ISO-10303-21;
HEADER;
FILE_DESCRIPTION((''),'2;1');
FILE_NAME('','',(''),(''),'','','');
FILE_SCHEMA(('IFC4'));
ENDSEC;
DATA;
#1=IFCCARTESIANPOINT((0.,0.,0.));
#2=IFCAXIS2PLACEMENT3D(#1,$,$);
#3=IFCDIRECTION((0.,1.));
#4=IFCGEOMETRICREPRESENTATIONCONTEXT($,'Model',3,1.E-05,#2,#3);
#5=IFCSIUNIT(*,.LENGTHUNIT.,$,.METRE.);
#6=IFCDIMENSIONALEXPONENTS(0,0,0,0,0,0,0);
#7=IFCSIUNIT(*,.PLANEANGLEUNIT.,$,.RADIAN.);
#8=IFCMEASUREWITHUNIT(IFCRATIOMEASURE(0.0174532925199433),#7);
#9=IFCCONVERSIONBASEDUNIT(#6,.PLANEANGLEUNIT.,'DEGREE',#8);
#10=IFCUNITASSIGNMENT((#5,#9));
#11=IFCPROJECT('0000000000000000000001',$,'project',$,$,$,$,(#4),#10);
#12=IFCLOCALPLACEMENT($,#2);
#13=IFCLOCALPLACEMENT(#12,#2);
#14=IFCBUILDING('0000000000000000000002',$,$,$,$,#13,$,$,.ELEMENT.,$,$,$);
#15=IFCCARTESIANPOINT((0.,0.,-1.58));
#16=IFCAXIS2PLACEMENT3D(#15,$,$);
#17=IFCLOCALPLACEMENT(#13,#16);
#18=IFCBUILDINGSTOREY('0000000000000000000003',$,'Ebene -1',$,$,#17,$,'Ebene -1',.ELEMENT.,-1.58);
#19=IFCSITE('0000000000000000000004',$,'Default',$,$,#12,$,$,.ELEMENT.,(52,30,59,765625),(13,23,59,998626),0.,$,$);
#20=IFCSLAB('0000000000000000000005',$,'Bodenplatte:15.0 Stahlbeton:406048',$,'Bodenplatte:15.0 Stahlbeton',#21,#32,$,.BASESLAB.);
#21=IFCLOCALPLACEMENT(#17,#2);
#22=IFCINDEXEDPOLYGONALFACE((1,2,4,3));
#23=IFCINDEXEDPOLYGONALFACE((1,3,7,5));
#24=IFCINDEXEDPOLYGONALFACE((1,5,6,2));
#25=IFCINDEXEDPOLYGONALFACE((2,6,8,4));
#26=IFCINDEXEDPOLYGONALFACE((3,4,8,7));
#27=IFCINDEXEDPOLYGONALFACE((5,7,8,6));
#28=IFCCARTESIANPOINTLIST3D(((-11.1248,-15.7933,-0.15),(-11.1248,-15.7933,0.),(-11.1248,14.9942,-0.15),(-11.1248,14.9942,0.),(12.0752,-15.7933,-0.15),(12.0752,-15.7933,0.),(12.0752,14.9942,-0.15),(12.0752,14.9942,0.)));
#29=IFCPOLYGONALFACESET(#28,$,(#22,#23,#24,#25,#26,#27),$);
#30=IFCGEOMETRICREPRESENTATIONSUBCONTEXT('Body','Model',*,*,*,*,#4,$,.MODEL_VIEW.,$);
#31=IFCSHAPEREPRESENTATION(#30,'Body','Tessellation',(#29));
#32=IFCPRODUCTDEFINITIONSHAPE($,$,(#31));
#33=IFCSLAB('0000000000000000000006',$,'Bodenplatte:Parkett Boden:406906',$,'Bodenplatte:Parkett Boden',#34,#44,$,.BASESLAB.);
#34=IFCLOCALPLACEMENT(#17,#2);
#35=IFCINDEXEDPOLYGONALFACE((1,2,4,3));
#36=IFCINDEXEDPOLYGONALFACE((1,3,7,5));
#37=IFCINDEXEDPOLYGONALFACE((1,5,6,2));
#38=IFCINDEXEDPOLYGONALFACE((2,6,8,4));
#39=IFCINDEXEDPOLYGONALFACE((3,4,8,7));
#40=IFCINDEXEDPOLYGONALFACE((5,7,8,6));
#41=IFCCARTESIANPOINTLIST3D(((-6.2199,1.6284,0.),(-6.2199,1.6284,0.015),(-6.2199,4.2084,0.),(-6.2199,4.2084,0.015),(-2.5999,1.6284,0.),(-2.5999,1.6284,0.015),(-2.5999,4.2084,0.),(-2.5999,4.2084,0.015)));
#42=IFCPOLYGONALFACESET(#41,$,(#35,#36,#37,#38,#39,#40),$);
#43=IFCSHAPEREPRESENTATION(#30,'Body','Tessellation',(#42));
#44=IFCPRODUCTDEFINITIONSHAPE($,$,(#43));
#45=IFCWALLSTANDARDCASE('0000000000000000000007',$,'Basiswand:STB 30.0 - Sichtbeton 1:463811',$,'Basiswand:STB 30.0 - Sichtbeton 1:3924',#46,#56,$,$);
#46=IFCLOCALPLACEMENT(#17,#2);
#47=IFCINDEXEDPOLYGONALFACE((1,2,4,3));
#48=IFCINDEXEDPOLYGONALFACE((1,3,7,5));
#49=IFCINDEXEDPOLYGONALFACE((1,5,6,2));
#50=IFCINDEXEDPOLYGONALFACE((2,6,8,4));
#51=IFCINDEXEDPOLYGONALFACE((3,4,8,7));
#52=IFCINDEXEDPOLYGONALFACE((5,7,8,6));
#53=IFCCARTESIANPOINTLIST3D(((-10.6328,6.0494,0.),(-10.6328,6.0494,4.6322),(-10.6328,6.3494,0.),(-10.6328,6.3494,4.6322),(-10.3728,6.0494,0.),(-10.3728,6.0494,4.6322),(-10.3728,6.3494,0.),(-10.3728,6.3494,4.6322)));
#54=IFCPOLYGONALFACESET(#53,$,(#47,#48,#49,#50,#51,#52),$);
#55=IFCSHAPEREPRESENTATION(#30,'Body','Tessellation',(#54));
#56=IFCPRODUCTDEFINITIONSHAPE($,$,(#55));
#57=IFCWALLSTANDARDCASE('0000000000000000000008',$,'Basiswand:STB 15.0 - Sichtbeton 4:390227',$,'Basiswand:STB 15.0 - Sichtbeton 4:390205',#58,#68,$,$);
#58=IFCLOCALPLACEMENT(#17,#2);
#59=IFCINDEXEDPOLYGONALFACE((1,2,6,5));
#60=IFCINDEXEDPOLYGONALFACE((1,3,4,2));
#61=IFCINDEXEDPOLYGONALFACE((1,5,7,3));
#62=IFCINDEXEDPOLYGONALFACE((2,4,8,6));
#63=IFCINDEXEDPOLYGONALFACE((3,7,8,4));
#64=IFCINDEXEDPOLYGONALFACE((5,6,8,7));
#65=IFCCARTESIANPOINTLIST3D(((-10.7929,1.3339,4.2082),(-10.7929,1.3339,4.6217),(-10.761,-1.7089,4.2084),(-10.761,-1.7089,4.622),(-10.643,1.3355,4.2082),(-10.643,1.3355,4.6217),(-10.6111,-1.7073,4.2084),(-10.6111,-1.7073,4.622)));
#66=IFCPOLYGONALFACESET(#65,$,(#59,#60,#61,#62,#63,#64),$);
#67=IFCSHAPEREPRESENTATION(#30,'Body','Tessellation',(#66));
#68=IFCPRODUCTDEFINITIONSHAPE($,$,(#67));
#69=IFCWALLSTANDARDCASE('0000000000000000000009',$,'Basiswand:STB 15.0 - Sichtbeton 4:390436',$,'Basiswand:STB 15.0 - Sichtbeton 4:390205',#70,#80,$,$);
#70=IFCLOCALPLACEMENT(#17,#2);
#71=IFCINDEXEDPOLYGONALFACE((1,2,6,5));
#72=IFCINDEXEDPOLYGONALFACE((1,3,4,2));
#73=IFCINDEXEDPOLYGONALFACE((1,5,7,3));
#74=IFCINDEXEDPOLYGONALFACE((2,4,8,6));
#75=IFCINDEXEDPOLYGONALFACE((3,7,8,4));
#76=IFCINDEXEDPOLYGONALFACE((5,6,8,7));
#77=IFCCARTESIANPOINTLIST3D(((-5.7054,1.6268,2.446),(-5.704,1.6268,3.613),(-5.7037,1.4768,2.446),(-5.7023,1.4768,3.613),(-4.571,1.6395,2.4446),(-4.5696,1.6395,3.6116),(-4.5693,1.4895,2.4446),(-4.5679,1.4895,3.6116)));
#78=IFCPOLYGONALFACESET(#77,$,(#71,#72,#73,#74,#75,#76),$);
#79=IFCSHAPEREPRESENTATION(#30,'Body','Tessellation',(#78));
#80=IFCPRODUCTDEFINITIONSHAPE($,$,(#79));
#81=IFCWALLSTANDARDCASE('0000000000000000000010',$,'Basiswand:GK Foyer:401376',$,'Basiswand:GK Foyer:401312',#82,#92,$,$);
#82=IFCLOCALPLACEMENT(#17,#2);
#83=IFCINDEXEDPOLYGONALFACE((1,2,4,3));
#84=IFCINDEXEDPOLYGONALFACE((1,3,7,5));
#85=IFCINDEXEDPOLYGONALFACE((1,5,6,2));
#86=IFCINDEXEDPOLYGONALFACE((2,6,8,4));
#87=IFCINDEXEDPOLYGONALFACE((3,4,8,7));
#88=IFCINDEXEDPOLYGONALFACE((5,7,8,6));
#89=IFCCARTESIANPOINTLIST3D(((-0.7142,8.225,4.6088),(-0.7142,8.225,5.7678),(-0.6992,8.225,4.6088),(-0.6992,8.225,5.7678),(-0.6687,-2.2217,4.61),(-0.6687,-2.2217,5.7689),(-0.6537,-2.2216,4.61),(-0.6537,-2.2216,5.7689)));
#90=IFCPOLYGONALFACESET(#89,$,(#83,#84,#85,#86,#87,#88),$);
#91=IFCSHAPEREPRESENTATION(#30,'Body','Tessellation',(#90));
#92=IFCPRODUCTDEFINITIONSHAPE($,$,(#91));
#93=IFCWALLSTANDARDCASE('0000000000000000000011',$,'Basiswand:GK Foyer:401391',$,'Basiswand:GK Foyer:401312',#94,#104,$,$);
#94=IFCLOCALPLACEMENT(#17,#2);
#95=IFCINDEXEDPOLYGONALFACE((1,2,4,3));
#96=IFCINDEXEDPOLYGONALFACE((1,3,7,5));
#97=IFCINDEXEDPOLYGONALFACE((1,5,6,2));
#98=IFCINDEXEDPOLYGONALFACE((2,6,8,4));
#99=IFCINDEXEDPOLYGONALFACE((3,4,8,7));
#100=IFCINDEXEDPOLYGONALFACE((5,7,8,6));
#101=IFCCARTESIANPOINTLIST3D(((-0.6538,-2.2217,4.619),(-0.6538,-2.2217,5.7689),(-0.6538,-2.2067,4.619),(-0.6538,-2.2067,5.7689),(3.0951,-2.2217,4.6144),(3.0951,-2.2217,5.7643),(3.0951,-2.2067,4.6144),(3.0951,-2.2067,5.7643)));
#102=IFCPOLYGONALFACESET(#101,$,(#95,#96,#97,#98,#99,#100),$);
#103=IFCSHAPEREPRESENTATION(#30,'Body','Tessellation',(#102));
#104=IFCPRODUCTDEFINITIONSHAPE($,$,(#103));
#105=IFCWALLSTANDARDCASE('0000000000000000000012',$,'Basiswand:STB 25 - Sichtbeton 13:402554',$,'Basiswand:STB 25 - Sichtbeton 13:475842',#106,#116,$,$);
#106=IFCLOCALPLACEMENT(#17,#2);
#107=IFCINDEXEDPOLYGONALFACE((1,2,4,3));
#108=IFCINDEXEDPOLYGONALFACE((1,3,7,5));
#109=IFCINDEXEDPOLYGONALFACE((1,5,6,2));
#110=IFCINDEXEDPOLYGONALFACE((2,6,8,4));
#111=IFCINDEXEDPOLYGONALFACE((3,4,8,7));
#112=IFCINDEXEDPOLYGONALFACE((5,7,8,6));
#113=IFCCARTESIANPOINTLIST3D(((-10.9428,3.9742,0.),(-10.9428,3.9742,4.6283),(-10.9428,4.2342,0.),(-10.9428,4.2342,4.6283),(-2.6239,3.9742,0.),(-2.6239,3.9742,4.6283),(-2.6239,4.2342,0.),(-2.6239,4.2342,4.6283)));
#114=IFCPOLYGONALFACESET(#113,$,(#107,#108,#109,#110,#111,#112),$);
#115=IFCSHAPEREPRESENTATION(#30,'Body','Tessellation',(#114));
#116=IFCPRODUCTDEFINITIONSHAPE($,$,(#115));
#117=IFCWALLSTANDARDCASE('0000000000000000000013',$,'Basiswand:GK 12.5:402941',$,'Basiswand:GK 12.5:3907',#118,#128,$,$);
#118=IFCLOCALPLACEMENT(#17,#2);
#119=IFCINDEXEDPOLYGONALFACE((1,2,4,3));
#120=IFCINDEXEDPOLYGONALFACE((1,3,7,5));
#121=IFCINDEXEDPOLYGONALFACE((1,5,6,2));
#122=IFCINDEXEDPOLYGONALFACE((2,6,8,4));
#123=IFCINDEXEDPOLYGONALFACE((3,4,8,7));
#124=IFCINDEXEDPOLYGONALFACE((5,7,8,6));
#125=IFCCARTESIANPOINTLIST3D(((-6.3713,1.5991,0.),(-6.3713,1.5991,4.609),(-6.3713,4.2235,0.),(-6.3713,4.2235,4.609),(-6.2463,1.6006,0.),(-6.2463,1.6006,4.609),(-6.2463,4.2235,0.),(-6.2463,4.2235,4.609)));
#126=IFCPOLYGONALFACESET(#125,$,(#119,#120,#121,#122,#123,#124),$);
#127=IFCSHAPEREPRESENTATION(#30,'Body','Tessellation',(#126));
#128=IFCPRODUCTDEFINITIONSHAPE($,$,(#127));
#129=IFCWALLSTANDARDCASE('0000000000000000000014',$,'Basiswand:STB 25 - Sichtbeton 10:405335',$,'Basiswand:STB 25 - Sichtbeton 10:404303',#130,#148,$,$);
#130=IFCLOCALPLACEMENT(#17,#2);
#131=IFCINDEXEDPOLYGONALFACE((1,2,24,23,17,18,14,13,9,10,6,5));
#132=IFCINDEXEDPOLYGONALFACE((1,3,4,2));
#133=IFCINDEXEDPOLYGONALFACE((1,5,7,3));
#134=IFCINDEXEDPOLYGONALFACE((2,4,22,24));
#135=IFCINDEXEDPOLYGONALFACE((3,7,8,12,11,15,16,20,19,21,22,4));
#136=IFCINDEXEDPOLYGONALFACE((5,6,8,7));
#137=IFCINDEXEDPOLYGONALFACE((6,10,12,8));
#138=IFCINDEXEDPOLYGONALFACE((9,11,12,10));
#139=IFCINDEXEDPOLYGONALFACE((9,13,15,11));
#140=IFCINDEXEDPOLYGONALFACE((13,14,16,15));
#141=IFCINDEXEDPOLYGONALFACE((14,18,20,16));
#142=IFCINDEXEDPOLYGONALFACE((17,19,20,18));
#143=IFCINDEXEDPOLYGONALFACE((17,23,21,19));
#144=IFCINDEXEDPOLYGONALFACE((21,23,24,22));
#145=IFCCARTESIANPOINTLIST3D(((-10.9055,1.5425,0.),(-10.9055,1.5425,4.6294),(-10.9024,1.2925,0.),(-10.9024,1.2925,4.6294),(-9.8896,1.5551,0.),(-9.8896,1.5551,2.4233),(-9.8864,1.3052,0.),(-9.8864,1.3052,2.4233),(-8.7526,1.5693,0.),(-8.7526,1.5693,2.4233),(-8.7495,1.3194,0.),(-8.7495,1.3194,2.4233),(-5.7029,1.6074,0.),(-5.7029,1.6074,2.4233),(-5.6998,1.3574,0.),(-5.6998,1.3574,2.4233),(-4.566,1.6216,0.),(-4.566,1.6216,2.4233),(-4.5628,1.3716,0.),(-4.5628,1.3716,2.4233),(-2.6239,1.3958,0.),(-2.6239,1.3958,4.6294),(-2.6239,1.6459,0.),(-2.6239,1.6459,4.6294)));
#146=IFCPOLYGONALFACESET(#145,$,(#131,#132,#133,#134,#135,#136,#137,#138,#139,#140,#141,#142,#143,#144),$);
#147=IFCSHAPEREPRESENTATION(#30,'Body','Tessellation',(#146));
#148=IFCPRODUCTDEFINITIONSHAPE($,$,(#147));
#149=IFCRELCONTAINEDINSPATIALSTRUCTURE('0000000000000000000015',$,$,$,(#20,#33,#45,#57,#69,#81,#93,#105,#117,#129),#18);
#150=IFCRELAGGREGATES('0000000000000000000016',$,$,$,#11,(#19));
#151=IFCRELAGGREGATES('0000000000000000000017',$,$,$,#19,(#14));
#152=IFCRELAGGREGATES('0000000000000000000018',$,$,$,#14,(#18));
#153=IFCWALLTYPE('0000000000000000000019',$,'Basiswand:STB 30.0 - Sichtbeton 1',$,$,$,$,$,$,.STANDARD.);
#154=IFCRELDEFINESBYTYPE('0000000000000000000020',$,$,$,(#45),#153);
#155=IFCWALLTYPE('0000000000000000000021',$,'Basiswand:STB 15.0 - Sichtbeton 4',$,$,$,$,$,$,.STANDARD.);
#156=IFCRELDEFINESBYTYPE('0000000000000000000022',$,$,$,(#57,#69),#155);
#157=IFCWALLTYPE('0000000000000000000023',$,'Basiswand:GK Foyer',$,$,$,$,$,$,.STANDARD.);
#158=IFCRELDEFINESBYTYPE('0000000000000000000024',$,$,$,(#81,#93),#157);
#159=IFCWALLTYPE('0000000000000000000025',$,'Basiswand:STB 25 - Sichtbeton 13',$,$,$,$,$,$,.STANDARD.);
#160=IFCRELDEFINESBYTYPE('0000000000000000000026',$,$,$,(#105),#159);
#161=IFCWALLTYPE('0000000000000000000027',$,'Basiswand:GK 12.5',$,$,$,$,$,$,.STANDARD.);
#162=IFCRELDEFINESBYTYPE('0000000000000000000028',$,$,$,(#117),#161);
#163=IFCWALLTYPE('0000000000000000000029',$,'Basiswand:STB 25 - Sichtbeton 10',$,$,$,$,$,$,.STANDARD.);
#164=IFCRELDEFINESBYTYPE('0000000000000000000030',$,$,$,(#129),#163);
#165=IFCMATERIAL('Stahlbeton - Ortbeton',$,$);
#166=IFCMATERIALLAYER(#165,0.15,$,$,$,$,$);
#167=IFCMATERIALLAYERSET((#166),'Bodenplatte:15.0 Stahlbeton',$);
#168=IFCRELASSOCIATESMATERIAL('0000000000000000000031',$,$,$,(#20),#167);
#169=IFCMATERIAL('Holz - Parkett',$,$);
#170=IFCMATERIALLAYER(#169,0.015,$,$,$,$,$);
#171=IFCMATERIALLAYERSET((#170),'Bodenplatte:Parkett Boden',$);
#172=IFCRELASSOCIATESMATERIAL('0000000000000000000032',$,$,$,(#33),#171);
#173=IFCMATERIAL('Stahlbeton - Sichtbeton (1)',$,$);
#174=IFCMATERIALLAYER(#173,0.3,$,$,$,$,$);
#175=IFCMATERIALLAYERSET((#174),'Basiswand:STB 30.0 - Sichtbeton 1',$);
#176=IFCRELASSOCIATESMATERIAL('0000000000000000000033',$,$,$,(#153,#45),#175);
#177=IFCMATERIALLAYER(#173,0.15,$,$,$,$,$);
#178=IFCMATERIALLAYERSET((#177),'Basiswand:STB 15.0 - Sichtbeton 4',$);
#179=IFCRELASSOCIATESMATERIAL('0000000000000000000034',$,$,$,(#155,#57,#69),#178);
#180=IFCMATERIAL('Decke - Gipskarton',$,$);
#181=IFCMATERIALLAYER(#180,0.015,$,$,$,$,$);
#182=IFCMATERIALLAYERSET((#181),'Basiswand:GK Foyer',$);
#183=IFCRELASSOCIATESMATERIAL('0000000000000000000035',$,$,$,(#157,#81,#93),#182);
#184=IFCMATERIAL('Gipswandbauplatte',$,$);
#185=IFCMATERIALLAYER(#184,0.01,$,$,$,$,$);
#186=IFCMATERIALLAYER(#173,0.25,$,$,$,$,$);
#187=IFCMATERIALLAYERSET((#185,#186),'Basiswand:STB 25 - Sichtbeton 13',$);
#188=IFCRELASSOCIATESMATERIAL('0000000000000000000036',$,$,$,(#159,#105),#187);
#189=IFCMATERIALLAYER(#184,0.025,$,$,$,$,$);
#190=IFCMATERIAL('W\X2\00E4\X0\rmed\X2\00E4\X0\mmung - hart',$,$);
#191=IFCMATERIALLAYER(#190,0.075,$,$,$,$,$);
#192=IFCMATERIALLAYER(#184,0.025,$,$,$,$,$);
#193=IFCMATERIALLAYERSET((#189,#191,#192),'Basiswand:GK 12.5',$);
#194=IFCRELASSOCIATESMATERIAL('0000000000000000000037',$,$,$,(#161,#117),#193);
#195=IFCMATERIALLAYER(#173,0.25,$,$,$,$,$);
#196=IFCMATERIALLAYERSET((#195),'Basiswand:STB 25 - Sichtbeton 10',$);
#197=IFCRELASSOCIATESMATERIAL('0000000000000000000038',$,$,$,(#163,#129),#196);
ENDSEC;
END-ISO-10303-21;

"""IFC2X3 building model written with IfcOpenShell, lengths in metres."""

from ifc_helpers import new_model, entity, si_unit, converted_unit, direction, frame, frame_2d, origin, origin_2d_with_axis, place, context, subcontext, project, spatial, polyline, rectangle, outline, extrude, clip, halfspace, material, layer, layer_set, layer_usage, type_object, element, save


model = new_model("IFC2X3")

# Units and contexts
model_context = context("Model", 3, precision=1e-05, world=origin(), true_north=direction((0.0, 1.0)))
body_context = subcontext(model_context, "Body", "Model", "MODEL_VIEW")
ifc_project = project(units=[si_unit("LENGTHUNIT", "METRE"), converted_unit("PLANEANGLEUNIT", "DEGREE", entity("IfcRatioMeasure", 0.0174532925199433), si_unit("PLANEANGLEUNIT", "RADIAN"), dimensions=[0, 0, 0, 0, 0, 0, 0])], contexts=[model_context])

# Site, building, storey
site_placement = place(None, origin())
site = spatial("IfcSite", under=ifc_project, at=site_placement, Name="Default", CompositionType="ELEMENT", RefLatitude=(52, 30, 59, 765625), RefLongitude=(13, 23, 59, 998626), RefElevation=0.0)
building_placement = place(site_placement, origin())
building = spatial("IfcBuilding", under=site, at=building_placement, CompositionType="ELEMENT")
storey_placement = place(building_placement, frame((0.0, 0.0, -1.58)))
storey = spatial("IfcBuildingStorey", under=building, at=storey_placement, Name="Ebene -1", LongName="Ebene -1", CompositionType="ELEMENT", Elevation=-1.58)

# Slabs
ifc_material_1 = material(Name="Stahlbeton - Ortbeton")
ifc_layer_1 = layer(ifc_material_1, 0.15)
ifc_layer_set_1 = layer_set([ifc_layer_1], Name="Bodenplatte:15.0 Stahlbeton")
ifc_layer_usage_1 = layer_usage(ifc_layer_set_1, "AXIS3", "POSITIVE", 0.0)
slab_1_placement = place(storey_placement, origin())
element("IfcSlab", 1, at=slab_1_placement, inside=storey, material=ifc_layer_usage_1, Name="Bodenplatte:15.0 Stahlbeton:406048", ObjectType="Bodenplatte:15.0 Stahlbeton", PredefinedType="BASESLAB", context=body_context, shape_type="SweptSolid", body=[
    extrude(rectangle(XDim=30.7875, YDim=23.2, at=frame_2d((0.0, 0.0), x_axis=(1.0, 0.0))), frame((0.4752, -0.3996, 0.0), z_axis=(0.0, 0.0, -1.0), x_axis=(0.0, 1.0, 0.0)), (0.0, 0.0, 1.0), 0.15),
])
ifc_material_2 = material(Name="Holz - Parkett")
ifc_layer_2 = layer(ifc_material_2, 0.015)
ifc_layer_set_2 = layer_set([ifc_layer_2], Name="Bodenplatte:Parkett Boden")
ifc_layer_usage_2 = layer_usage(ifc_layer_set_2, "AXIS3", "POSITIVE", 0.0)
slab_2_placement = place(storey_placement, origin())
element("IfcSlab", 2, at=slab_2_placement, inside=storey, material=ifc_layer_usage_2, Name="Bodenplatte:Parkett Boden:406906", ObjectType="Bodenplatte:Parkett Boden", PredefinedType="BASESLAB", context=body_context, shape_type="SweptSolid", body=[
    extrude(rectangle(XDim=2.58, YDim=3.62, at=origin_2d_with_axis()), frame((-4.4099, 2.9184, 0.015), z_axis=(0.0, 0.0, -1.0), x_axis=(0.0, 1.0, 0.0)), (0.0, 0.0, 1.0), 0.015),
])

# Walls
ifc_material_3 = material(Name="Stahlbeton - Sichtbeton (1)")
ifc_layer_3 = layer(ifc_material_3, 0.3)
ifc_layer_set_3 = layer_set([ifc_layer_3], Name="Basiswand:STB 30.0 - Sichtbeton 1")
ifc_layer_usage_3 = layer_usage(ifc_layer_set_3, "AXIS2", "NEGATIVE", 0.15)
wall_type_1 = type_object("IfcWallType", Name="Basiswand:STB 30.0 - Sichtbeton 1", PredefinedType="STANDARD", material=ifc_layer_set_3)
wall_1_placement = place(storey_placement, frame((-10.3728, 6.1994, 0.0), z_axis=(0.0, 0.0, 1.0), x_axis=(-1.0, 0.0, 0.0)))
element("IfcWallStandardCase", 3, at=wall_1_placement, inside=storey, type_object=wall_type_1, material=ifc_layer_usage_3, Name="Basiswand:STB 30.0 - Sichtbeton 1:463811", ObjectType="Basiswand:STB 30.0 - Sichtbeton 1:3924", context=body_context, shape_type="SweptSolid", body=[
    extrude(rectangle(XDim=0.26, YDim=0.3, at=frame_2d((0.13, 0.0), x_axis=(-1.0, 0.0))), origin(), (0.0, 0.0, 1.0), 4.6322),
])
ifc_layer_4 = layer(ifc_material_3, 0.15)
ifc_layer_set_4 = layer_set([ifc_layer_4], Name="Basiswand:STB 15.0 - Sichtbeton 4")
ifc_layer_usage_4 = layer_usage(ifc_layer_set_4, "AXIS2", "POSITIVE", -0.075)
wall_type_2 = type_object("IfcWallType", Name="Basiswand:STB 15.0 - Sichtbeton 4", PredefinedType="STANDARD", material=ifc_layer_set_4)
wall_2_placement = place(storey_placement, frame((-10.6861, -1.7081, 4.2082), z_axis=(0.0, 0.0, 1.0), x_axis=(-0.010482, 0.999945, 0.0)))
element("IfcWallStandardCase", 4, at=wall_2_placement, inside=storey, type_object=wall_type_2, material=ifc_layer_usage_4, Name="Basiswand:STB 15.0 - Sichtbeton 4:390227", ObjectType="Basiswand:STB 15.0 - Sichtbeton 4:390205", context=body_context, shape_type="Clipping", body=[
    clip(clip(clip(extrude(rectangle(XDim=3.0429, YDim=0.15, at=frame_2d((1.5215, 0.0), x_axis=(-1.0, 0.0))), origin(), (0.0, 0.0, 1.0), 0.4138), halfspace(frame((0.0, -0.075, 0.4138), z_axis=(0.0001, 0.0, 1.0), x_axis=(0.0, 1.0, 0.0)), False)), halfspace(frame((3.0429, -0.075, 0.0), z_axis=(-0.00007, 0.0, -1.0), x_axis=(0.0, 1.0, 0.0)), False)), halfspace(frame((3.0429, -0.075, 0.4135), z_axis=(1.0, 0.0, -0.0001), x_axis=(0.0, 1.0, 0.0)), False)),
])
ifc_layer_usage_5 = layer_usage(ifc_layer_set_4, "AXIS2", "POSITIVE", -0.075)
wall_3_placement = place(storey_placement, frame((-4.5687, 1.5645, 2.4446), z_axis=(0.0, 0.0, 1.0), x_axis=(-0.999938, -0.011156, 0.0)))
element("IfcWallStandardCase", 5, at=wall_3_placement, inside=storey, type_object=wall_type_2, material=ifc_layer_usage_5, Name="Basiswand:STB 15.0 - Sichtbeton 4:390436", ObjectType="Basiswand:STB 15.0 - Sichtbeton 4:390205", context=body_context, shape_type="Clipping", body=[
    clip(clip(clip(clip(extrude(rectangle(XDim=1.1359, YDim=0.15, at=frame_2d((0.5679, 0.0), x_axis=(-1.0, 0.0))), origin(), (0.0, 0.0, 1.0), 1.1684), halfspace(frame((1.1345, -0.075, 1.1684), z_axis=(0.999999, 0.0, 0.001216), x_axis=(0.0, 1.0, 0.0)), False)), halfspace(frame((0.0, -0.075, 1.167), z_axis=(-0.001216, 0.0, 0.999999), x_axis=(0.0, 1.0, 0.0)), False)), halfspace(frame((0.0014, -0.075, 0.0), z_axis=(-0.999999, 0.0, -0.001218), x_axis=(0.0, 1.0, 0.0)), False)), halfspace(frame((1.1359, -0.075, 0.0014), z_axis=(0.001216, 0.0, -0.999999), x_axis=(0.0, 1.0, 0.0)), False)),
])
ifc_material_4 = material(Name="Decke - Gipskarton")
ifc_layer_5 = layer(ifc_material_4, 0.015)
ifc_layer_set_5 = layer_set([ifc_layer_5], Name="Basiswand:GK Foyer")
ifc_layer_usage_6 = layer_usage(ifc_layer_set_5, "AXIS2", "POSITIVE", -0.0075)
wall_type_3 = type_object("IfcWallType", Name="Basiswand:GK Foyer", PredefinedType="STANDARD", material=ifc_layer_set_5)
wall_4_placement = place(storey_placement, frame((-0.7067, 8.225, 4.6088), z_axis=(0.0, 0.0, 1.0), x_axis=(0.004357, -0.999991, 0.0)))
element("IfcWallStandardCase", 6, at=wall_4_placement, inside=storey, type_object=wall_type_3, material=ifc_layer_usage_6, Name="Basiswand:GK Foyer:401376", ObjectType="Basiswand:GK Foyer:401312", context=body_context, shape_type="Clipping", body=[
    clip(clip(clip(clip(extrude(rectangle(XDim=10.4468, YDim=0.015, at=frame_2d((5.2234, 0.0), x_axis=(-1.0, 0.0))), origin(), (0.0, 0.0, 1.0), 1.16), halfspace(frame((0.0001, -0.0075, 0.0), z_axis=(-1.0, 0.0, -0.000108), x_axis=(0.0, 1.0, 0.0)), False)), halfspace(frame((10.4468, -0.0075, 0.0011), z_axis=(0.000108, 0.0, -1.0), x_axis=(0.0, 1.0, 0.0)), False)), halfspace(frame((10.4466, -0.0075, 1.16), z_axis=(1.0, 0.0, 0.000108), x_axis=(0.0, 1.0, 0.0)), False)), halfspace(frame((0.0, -0.0075, 1.1589), z_axis=(-0.000108, 0.0, 1.0), x_axis=(0.0, 1.0, 0.0)), False)),
])
ifc_layer_usage_7 = layer_usage(ifc_layer_set_5, "AXIS2", "POSITIVE", -0.0075)
wall_5_placement = place(storey_placement, frame((-0.6538, -2.2142, 4.6144)))
element("IfcWallStandardCase", 7, at=wall_5_placement, inside=storey, type_object=wall_type_3, material=ifc_layer_usage_7, Name="Basiswand:GK Foyer:401391", ObjectType="Basiswand:GK Foyer:401312", context=body_context, shape_type="Clipping", body=[
    clip(clip(extrude(rectangle(XDim=3.7489, YDim=0.015, at=frame_2d((1.8745, 0.0), x_axis=(-1.0, 0.0))), origin(), (0.0, 0.0, 1.0), 1.1545), halfspace(frame((3.7489, -0.0075, 0.0), z_axis=(-0.001215, 0.0, -0.999999), x_axis=(0.0, 1.0, 0.0)), False)), halfspace(frame((0.0001, -0.0075, 1.1545), z_axis=(0.001215, 0.0, 0.999999), x_axis=(0.0, 1.0, 0.0)), False)),
])
ifc_material_5 = material(Name="Gipswandbauplatte")
ifc_layer_6 = layer(ifc_material_5, 0.01)
ifc_layer_7 = layer(ifc_material_3, 0.25)
ifc_layer_set_6 = layer_set([ifc_layer_6, ifc_layer_7], Name="Basiswand:STB 25 - Sichtbeton 13")
ifc_layer_usage_8 = layer_usage(ifc_layer_set_6, "AXIS2", "POSITIVE", -0.13)
wall_type_4 = type_object("IfcWallType", Name="Basiswand:STB 25 - Sichtbeton 13", PredefinedType="STANDARD", material=ifc_layer_set_6)
wall_6_placement = place(storey_placement, frame((-2.6239, 4.1042, 0.0), z_axis=(0.0, 0.0, 1.0), x_axis=(-1.0, 0.0, 0.0)))
element("IfcWallStandardCase", 8, at=wall_6_placement, inside=storey, type_object=wall_type_4, material=ifc_layer_usage_8, Name="Basiswand:STB 25 - Sichtbeton 13:402554", ObjectType="Basiswand:STB 25 - Sichtbeton 13:475842", context=body_context, shape_type="SweptSolid", body=[
    extrude(rectangle(XDim=8.3189, YDim=0.26, at=frame_2d((4.1594, 0.0), x_axis=(-1.0, 0.0))), origin(), (0.0, 0.0, 1.0), 4.6283),
])
ifc_layer_8 = layer(ifc_material_5, 0.025)
ifc_material_6 = material(Name="Wärmedämmung - hart")
ifc_layer_9 = layer(ifc_material_6, 0.075)
ifc_layer_10 = layer(ifc_material_5, 0.025)
ifc_layer_set_7 = layer_set([ifc_layer_8, ifc_layer_9, ifc_layer_10], Name="Basiswand:GK 12.5")
ifc_layer_usage_9 = layer_usage(ifc_layer_set_7, "AXIS2", "NEGATIVE", 0.0625)
wall_type_5 = type_object("IfcWallType", Name="Basiswand:GK 12.5", PredefinedType="STANDARD", material=ifc_layer_set_7)
wall_7_placement = place(storey_placement, frame((-6.3088, 4.2235, 0.0), z_axis=(0.0, 0.0, 1.0), x_axis=(0.0, -1.0, 0.0)))
element("IfcWallStandardCase", 9, at=wall_7_placement, inside=storey, type_object=wall_type_5, material=ifc_layer_usage_9, Name="Basiswand:GK 12.5:402941", ObjectType="Basiswand:GK 12.5:3907", context=body_context, shape_type="SweptSolid", body=[
    extrude(outline(polyline([(2.6244, -0.0625), (2.6228, 0.0625), (0.0, 0.0625), (0.0, -0.0625), (2.6244, -0.0625)])), origin(), (0.0, 0.0, 1.0), 4.609),
])

# Wall, openings
ifc_layer_11 = layer(ifc_material_3, 0.25)
ifc_layer_set_8 = layer_set([ifc_layer_11], Name="Basiswand:STB 25 - Sichtbeton 10")
ifc_layer_usage_10 = layer_usage(ifc_layer_set_8, "AXIS2", "NEGATIVE", 0.125)
wall_type_6 = type_object("IfcWallType", Name="Basiswand:STB 25 - Sichtbeton 10", PredefinedType="STANDARD", material=ifc_layer_set_8)
wall_8_placement = place(storey_placement, frame((-2.6224, 1.5209, 0.0), z_axis=(0.0, 0.0, 1.0), x_axis=(-0.999922, -0.012485, 0.0)))
wall_8 = element("IfcWallStandardCase", 10, at=wall_8_placement, inside=storey, type_object=wall_type_6, material=ifc_layer_usage_10, Name="Basiswand:STB 25 - Sichtbeton 10:405335", ObjectType="Basiswand:STB 25 - Sichtbeton 10:404303", context=body_context, shape_type="SweptSolid", body=[
    extrude(outline(polyline([(0.0, -0.125), (8.2822, -0.125), (8.2822, 0.125), (0.0031, 0.125), (0.0, -0.125)])), origin(), (0.0, 0.0, 1.0), 4.6294),
])
opening_1_placement = place(wall_8_placement, frame((3.0792, 0.125, 0.0)))
element("IfcOpeningElement", 11, at=opening_1_placement, cuts=wall_8, ObjectType="Opening", context=body_context, shape_type="SweptSolid", body=[
    extrude(rectangle(XDim=2.4233, YDim=1.137, at=frame_2d((1.2116, 0.5685), x_axis=(1.0, 0.0))), frame((0.0, 0.0, 0.0), z_axis=(0.0, -1.0, 0.0), x_axis=(0.0, 0.0, 1.0)), (0.0, 0.0, 1.0), 0.25),
])
opening_2_placement = place(wall_8_placement, frame((7.2662, 0.125, 0.0)))
element("IfcOpeningElement", 12, at=opening_2_placement, cuts=wall_8, ObjectType="Opening", context=body_context, shape_type="SweptSolid", body=[
    extrude(rectangle(XDim=2.4233, YDim=1.137, at=frame_2d((1.2116, 0.5685), x_axis=(1.0, 0.0))), frame((0.0, 0.0, 0.0), z_axis=(0.0, -1.0, 0.0), x_axis=(0.0, 0.0, 1.0)), (0.0, 0.0, 1.0), 0.25),
])

save(model, "model.ifc")
